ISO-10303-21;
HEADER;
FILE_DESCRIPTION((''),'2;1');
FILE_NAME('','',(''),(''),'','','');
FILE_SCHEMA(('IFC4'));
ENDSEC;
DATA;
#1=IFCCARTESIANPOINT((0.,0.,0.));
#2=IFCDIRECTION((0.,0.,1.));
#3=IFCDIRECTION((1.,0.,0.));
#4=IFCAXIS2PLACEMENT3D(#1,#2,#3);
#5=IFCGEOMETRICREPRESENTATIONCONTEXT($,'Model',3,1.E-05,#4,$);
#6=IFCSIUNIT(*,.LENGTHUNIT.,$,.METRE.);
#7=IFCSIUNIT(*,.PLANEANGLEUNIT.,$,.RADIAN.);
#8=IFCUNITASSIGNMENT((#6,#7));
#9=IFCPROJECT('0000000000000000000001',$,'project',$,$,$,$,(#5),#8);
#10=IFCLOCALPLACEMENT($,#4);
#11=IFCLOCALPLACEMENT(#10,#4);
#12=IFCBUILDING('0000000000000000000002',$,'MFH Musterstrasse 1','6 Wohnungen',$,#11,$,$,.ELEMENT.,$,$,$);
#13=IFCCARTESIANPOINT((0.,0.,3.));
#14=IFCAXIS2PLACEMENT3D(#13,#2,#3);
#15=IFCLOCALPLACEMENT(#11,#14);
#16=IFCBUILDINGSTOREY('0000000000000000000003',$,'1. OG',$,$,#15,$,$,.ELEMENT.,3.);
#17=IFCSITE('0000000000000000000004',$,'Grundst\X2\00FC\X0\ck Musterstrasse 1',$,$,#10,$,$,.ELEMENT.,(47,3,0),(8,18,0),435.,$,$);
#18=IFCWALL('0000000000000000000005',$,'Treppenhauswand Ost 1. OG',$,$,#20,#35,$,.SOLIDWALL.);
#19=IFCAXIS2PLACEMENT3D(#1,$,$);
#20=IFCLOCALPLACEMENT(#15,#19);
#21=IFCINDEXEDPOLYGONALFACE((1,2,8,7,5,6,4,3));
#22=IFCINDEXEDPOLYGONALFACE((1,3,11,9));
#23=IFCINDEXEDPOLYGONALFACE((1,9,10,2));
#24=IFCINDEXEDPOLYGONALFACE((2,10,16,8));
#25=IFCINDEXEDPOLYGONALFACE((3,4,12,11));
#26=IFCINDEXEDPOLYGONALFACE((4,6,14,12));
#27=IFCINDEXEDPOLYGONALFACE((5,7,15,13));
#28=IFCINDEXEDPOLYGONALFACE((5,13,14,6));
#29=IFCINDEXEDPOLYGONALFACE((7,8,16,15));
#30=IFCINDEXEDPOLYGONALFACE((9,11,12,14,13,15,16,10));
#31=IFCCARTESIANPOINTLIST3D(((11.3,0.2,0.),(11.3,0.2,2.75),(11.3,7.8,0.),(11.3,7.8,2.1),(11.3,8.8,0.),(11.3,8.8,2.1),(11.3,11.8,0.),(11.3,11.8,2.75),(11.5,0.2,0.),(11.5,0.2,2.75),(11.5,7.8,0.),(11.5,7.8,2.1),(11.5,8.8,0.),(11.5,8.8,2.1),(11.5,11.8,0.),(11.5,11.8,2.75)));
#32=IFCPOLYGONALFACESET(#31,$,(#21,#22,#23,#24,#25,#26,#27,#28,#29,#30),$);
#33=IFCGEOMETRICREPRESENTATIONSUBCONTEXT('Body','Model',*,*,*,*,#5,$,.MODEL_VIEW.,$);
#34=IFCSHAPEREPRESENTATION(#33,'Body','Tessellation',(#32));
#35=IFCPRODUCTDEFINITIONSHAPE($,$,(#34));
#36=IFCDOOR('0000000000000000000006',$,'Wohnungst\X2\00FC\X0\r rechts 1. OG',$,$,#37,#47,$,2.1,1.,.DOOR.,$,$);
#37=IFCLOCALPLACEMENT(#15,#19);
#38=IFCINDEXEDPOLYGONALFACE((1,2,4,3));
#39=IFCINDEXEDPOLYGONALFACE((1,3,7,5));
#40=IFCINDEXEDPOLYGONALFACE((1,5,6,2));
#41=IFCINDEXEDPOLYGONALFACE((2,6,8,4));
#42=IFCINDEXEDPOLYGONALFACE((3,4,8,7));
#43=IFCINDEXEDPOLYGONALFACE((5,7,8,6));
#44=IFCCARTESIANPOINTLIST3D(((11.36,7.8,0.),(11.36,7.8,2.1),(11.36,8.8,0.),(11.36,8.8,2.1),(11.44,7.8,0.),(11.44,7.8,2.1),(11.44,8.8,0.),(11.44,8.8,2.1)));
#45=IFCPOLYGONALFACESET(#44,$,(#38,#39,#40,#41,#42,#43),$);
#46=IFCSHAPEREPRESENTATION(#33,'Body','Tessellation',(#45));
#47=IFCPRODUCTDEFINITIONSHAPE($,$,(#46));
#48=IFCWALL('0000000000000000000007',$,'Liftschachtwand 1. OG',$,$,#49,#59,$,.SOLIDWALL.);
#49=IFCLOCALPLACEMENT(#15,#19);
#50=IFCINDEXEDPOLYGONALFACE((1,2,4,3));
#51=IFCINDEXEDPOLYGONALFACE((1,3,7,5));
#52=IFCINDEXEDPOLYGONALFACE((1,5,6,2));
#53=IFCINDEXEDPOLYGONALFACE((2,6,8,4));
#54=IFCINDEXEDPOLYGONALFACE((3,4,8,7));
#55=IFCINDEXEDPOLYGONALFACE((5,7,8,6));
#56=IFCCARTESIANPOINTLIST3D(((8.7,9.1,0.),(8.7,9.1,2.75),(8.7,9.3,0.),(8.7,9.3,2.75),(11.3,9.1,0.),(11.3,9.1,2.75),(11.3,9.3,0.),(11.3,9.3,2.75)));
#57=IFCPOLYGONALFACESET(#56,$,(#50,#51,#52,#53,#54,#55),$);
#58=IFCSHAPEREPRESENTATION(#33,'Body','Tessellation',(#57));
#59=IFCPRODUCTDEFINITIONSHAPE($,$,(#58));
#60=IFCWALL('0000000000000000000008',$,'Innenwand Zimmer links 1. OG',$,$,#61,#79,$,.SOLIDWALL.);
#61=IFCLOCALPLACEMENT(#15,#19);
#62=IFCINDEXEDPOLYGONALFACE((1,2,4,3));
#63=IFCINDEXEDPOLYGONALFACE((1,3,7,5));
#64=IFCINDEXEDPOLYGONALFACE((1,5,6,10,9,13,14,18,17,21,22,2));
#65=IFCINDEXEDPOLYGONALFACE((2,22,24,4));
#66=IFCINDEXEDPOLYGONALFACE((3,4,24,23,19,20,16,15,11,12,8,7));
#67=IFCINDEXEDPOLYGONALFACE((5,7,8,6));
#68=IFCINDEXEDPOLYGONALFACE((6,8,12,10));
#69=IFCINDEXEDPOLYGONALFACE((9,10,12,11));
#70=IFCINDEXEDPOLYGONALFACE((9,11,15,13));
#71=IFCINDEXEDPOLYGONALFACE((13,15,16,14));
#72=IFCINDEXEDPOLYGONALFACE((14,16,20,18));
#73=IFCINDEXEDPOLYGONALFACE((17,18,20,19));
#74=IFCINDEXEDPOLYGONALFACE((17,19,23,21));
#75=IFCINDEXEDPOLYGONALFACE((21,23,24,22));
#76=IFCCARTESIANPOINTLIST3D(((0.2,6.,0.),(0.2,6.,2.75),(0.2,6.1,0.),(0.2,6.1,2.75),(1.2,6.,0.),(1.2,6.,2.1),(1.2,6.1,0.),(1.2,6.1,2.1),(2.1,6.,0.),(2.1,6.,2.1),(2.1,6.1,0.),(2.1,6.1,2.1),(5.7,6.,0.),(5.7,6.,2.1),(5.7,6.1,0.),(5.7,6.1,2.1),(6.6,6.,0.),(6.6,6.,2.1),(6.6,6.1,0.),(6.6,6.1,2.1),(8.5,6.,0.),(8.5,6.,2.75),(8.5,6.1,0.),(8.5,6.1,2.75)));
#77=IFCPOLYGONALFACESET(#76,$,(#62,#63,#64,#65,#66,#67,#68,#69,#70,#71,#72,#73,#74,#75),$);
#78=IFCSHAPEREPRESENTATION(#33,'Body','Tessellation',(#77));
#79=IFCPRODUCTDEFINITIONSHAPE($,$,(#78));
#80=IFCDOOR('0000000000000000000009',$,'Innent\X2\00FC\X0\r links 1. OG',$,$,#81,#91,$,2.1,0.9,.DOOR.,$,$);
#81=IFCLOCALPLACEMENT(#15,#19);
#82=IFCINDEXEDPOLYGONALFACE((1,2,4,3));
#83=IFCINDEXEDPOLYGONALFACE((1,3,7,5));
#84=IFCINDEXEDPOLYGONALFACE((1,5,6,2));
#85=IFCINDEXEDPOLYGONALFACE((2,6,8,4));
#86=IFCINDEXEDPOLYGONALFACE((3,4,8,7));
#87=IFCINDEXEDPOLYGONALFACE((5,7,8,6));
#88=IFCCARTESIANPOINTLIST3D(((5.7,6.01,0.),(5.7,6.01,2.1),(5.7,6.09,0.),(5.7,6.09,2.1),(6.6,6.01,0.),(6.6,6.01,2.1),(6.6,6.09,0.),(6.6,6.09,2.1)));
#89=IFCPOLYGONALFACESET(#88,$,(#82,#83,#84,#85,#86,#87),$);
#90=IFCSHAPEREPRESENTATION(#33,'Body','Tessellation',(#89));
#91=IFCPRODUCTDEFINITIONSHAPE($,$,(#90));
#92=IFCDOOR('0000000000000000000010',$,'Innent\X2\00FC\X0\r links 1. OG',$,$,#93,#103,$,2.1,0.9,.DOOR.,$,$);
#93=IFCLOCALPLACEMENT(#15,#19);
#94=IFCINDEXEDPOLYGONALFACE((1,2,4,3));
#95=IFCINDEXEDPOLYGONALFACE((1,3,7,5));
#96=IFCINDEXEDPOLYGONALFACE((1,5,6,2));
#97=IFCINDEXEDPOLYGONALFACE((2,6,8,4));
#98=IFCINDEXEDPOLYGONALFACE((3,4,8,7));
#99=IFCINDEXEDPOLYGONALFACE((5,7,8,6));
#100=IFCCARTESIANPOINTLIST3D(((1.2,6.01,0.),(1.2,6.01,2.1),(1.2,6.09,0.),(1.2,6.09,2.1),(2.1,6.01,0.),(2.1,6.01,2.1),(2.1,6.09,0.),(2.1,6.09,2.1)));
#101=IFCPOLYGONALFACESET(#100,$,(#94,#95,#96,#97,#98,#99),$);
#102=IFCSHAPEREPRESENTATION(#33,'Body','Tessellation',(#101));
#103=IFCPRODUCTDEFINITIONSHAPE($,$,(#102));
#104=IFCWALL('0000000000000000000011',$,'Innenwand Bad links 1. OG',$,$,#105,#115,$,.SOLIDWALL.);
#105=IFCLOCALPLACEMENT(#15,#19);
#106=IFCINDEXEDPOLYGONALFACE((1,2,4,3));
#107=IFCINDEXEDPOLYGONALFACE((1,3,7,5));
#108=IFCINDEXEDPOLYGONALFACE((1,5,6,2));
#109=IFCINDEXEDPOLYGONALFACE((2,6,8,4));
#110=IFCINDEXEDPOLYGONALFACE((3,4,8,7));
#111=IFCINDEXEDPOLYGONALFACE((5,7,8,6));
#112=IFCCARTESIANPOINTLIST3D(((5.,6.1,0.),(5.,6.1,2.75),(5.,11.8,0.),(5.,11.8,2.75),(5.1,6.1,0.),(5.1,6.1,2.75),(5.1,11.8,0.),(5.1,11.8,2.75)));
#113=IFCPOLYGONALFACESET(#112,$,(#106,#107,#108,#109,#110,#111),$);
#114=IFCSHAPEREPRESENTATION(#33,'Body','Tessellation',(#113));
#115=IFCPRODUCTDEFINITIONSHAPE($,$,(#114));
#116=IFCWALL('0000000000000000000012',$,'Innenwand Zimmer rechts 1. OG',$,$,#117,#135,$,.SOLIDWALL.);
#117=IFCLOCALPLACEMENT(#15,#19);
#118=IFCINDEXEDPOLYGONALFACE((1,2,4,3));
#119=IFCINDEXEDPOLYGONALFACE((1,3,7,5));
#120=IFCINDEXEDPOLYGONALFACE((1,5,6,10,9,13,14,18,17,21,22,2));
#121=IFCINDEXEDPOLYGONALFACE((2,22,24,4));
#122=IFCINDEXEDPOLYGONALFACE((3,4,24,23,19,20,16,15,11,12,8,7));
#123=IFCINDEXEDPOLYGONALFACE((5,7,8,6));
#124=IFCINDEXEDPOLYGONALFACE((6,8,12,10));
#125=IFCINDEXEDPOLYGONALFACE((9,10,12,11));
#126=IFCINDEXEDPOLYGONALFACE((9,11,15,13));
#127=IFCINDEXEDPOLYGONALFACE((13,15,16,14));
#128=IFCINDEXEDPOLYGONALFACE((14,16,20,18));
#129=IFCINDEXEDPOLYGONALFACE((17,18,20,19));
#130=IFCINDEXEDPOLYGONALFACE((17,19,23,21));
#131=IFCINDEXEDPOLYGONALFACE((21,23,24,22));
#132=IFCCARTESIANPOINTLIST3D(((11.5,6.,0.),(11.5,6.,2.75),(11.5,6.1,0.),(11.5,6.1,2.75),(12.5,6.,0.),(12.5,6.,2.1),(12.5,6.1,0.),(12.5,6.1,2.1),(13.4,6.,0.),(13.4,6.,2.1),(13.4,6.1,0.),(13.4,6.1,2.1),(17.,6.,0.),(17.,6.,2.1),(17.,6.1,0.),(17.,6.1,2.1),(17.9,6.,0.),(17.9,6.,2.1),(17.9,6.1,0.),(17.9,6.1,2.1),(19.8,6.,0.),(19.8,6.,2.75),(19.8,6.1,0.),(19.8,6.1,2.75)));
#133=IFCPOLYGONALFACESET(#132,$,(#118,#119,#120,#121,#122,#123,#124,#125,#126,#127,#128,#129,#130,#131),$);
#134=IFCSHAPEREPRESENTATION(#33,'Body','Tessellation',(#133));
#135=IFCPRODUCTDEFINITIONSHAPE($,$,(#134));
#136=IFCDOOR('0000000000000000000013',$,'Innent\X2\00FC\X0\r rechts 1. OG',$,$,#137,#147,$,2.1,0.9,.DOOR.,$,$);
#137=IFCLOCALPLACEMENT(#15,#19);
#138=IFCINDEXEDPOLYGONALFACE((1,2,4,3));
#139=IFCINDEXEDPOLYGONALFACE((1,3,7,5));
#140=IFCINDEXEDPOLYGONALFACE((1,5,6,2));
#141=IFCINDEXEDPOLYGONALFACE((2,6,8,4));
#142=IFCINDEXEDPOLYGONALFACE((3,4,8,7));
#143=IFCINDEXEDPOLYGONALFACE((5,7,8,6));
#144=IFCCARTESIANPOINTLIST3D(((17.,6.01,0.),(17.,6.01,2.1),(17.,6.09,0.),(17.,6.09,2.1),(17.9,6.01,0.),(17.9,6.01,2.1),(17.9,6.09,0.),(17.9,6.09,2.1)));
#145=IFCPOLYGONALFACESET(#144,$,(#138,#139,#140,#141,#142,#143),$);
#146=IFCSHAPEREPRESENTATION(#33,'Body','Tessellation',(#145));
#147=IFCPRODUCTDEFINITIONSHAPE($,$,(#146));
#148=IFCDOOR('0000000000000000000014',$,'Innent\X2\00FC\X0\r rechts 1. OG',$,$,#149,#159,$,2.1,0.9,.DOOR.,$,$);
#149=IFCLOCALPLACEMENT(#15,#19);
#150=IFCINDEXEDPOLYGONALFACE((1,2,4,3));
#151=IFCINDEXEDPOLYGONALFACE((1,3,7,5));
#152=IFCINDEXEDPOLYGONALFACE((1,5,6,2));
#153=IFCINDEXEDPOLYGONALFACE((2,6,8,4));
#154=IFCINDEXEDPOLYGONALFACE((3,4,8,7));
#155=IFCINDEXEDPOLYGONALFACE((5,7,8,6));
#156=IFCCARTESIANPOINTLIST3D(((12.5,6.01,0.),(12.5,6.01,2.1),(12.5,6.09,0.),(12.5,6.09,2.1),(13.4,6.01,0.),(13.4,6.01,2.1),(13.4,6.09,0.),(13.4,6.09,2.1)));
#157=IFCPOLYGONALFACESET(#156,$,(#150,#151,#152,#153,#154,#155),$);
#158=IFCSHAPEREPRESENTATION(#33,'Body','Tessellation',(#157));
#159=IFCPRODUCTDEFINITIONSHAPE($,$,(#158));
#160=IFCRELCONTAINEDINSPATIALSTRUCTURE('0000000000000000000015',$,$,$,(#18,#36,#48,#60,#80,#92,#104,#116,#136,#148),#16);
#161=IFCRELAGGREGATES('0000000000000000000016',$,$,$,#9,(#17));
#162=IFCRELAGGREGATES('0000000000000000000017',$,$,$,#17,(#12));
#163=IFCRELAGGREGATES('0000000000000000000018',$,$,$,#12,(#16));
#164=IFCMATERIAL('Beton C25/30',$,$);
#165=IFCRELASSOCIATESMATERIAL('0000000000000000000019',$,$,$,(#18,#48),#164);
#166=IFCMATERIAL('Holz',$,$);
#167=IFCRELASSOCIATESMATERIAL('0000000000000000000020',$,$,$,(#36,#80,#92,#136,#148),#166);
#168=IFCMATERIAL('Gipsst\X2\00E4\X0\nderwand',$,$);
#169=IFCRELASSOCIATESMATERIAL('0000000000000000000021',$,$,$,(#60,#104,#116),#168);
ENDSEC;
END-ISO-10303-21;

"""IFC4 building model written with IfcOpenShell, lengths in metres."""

from ifc_helpers import new_model, si_unit, frame, frame_2d, origin_with_axes, place, context, subcontext, project, spatial, rectangle, extrude, material, element, fill, save


model = new_model("IFC4")

# Units and contexts
model_context = context("Model", 3, precision=1e-05, world=origin_with_axes())
body_context = subcontext(model_context, "Body", "Model", "MODEL_VIEW")
ifc_project = project(units=[si_unit("LENGTHUNIT", "METRE"), si_unit("PLANEANGLEUNIT", "RADIAN")], contexts=[model_context])

# Site, building, storey
site_placement = place(None, origin_with_axes())
site = spatial("IfcSite", under=ifc_project, at=site_placement, Name="Grundstück Musterstrasse 1", CompositionType="ELEMENT", RefLatitude=(47, 3, 0), RefLongitude=(8, 18, 0), RefElevation=435.0)
building_placement = place(site_placement, origin_with_axes())
building = spatial("IfcBuilding", under=site, at=building_placement, Name="MFH Musterstrasse 1", Description="6 Wohnungen", CompositionType="ELEMENT")
storey_placement = place(building_placement, frame((0.0, 0.0, 3.0), z_axis=(0.0, 0.0, 1.0), x_axis=(1.0, 0.0, 0.0)))
storey = spatial("IfcBuildingStorey", under=building, at=storey_placement, Name="1. OG", CompositionType="ELEMENT", Elevation=3.0)

# Wall, openings, door
ifc_material_1 = material(Name="Beton C25/30")
wall_1_placement = place(storey_placement, origin_with_axes())
wall_1 = element("IfcWall", 1, at=wall_1_placement, inside=storey, material=ifc_material_1, Name="Treppenhauswand Ost 1. OG", PredefinedType="SOLIDWALL", context=body_context, shape_type="SweptSolid", body=[
    extrude(rectangle(XDim=0.2, YDim=11.6, at=frame_2d((0.1, 5.8), x_axis=(1.0, 0.0))), frame((11.3, 0.2, 0.0), z_axis=(0.0, 0.0, 1.0), x_axis=(1.0, 0.0, 0.0)), (0.0, 0.0, 1.0), 2.75),
])
opening_1_placement = place(storey_placement, origin_with_axes())
element("IfcOpeningElement", 2, at=opening_1_placement, cuts=wall_1, PredefinedType="OPENING", context=body_context, shape_type="SweptSolid", body=[
    extrude(rectangle(XDim=0.3, YDim=1.0, at=frame_2d((0.15, 0.5), x_axis=(1.0, 0.0))), frame((11.25, 7.8, 0.0), z_axis=(0.0, 0.0, 1.0), x_axis=(1.0, 0.0, 0.0)), (0.0, 0.0, 1.0), 2.1),
])
opening_2_placement = place(storey_placement, origin_with_axes())
opening_2 = element("IfcOpeningElement", 3, at=opening_2_placement, cuts=wall_1, PredefinedType="OPENING", context=body_context, shape_type="SweptSolid", body=[
    extrude(rectangle(XDim=0.22, YDim=1.0, at=frame_2d((0.11, 0.5), x_axis=(1.0, 0.0))), frame((11.29, 7.8, 0.0), z_axis=(0.0, 0.0, 1.0), x_axis=(1.0, 0.0, 0.0)), (0.0, 0.0, 1.0), 2.1),
])
ifc_material_2 = material(Name="Holz")
door_1_placement = place(storey_placement, origin_with_axes())
door_1 = element("IfcDoor", 4, at=door_1_placement, inside=storey, material=ifc_material_2, Name="Wohnungstür rechts 1. OG", OverallHeight=2.1, OverallWidth=1.0, PredefinedType="DOOR", context=body_context, shape_type="SweptSolid", body=[
    extrude(rectangle(XDim=0.08, YDim=1.0, at=frame_2d((0.04, 0.5), x_axis=(1.0, 0.0))), frame((11.36, 7.8, 0.0), z_axis=(0.0, 0.0, 1.0), x_axis=(1.0, 0.0, 0.0)), (0.0, 0.0, 1.0), 2.1),
])
fill(opening_2, door_1)

# Wall
wall_2_placement = place(storey_placement, origin_with_axes())
element("IfcWall", 5, at=wall_2_placement, inside=storey, material=ifc_material_1, Name="Liftschachtwand 1. OG", PredefinedType="SOLIDWALL", context=body_context, shape_type="SweptSolid", body=[
    extrude(rectangle(XDim=2.6, YDim=0.2, at=frame_2d((1.3, 0.1), x_axis=(1.0, 0.0))), frame((8.7, 9.1, 0.0), z_axis=(0.0, 0.0, 1.0), x_axis=(1.0, 0.0, 0.0)), (0.0, 0.0, 1.0), 2.75),
])

# Wall, openings, doors
ifc_material_3 = material(Name="Gipsständerwand")
wall_3_placement = place(storey_placement, origin_with_axes())
wall_3 = element("IfcWall", 6, at=wall_3_placement, inside=storey, material=ifc_material_3, Name="Innenwand Zimmer links 1. OG", PredefinedType="SOLIDWALL", context=body_context, shape_type="SweptSolid", body=[
    extrude(rectangle(XDim=8.3, YDim=0.1, at=frame_2d((4.15, 0.05), x_axis=(1.0, 0.0))), frame((0.2, 6.0, 0.0), z_axis=(0.0, 0.0, 1.0), x_axis=(1.0, 0.0, 0.0)), (0.0, 0.0, 1.0), 2.75),
])
opening_3_placement = place(storey_placement, origin_with_axes())
element("IfcOpeningElement", 7, at=opening_3_placement, cuts=wall_3, PredefinedType="OPENING", context=body_context, shape_type="SweptSolid", body=[
    extrude(rectangle(XDim=0.9, YDim=0.2, at=frame_2d((0.45, 0.1), x_axis=(1.0, 0.0))), frame((5.7, 5.95, 0.0), z_axis=(0.0, 0.0, 1.0), x_axis=(1.0, 0.0, 0.0)), (0.0, 0.0, 1.0), 2.1),
])
opening_4_placement = place(storey_placement, origin_with_axes())
element("IfcOpeningElement", 8, at=opening_4_placement, cuts=wall_3, PredefinedType="OPENING", context=body_context, shape_type="SweptSolid", body=[
    extrude(rectangle(XDim=0.9, YDim=0.2, at=frame_2d((0.45, 0.1), x_axis=(1.0, 0.0))), frame((1.2, 5.95, 0.0), z_axis=(0.0, 0.0, 1.0), x_axis=(1.0, 0.0, 0.0)), (0.0, 0.0, 1.0), 2.1),
])
opening_5_placement = place(storey_placement, origin_with_axes())
opening_5 = element("IfcOpeningElement", 9, at=opening_5_placement, cuts=wall_3, PredefinedType="OPENING", context=body_context, shape_type="SweptSolid", body=[
    extrude(rectangle(XDim=0.9, YDim=0.12, at=frame_2d((0.45, 0.06), x_axis=(1.0, 0.0))), frame((5.7, 5.99, 0.0), z_axis=(0.0, 0.0, 1.0), x_axis=(1.0, 0.0, 0.0)), (0.0, 0.0, 1.0), 2.1),
])
opening_6_placement = place(storey_placement, origin_with_axes())
opening_6 = element("IfcOpeningElement", 10, at=opening_6_placement, cuts=wall_3, PredefinedType="OPENING", context=body_context, shape_type="SweptSolid", body=[
    extrude(rectangle(XDim=0.9, YDim=0.12, at=frame_2d((0.45, 0.06), x_axis=(1.0, 0.0))), frame((1.2, 5.99, 0.0), z_axis=(0.0, 0.0, 1.0), x_axis=(1.0, 0.0, 0.0)), (0.0, 0.0, 1.0), 2.1),
])
door_2_placement = place(storey_placement, origin_with_axes())
door_2 = element("IfcDoor", 11, at=door_2_placement, inside=storey, material=ifc_material_2, Name="Innentür links 1. OG", OverallHeight=2.1, OverallWidth=0.9, PredefinedType="DOOR", context=body_context, shape_type="SweptSolid", body=[
    extrude(rectangle(XDim=0.9, YDim=0.08, at=frame_2d((0.45, 0.04), x_axis=(1.0, 0.0))), frame((5.7, 6.01, 0.0), z_axis=(0.0, 0.0, 1.0), x_axis=(1.0, 0.0, 0.0)), (0.0, 0.0, 1.0), 2.1),
])
fill(opening_5, door_2)
door_3_placement = place(storey_placement, origin_with_axes())
door_3 = element("IfcDoor", 12, at=door_3_placement, inside=storey, material=ifc_material_2, Name="Innentür links 1. OG", OverallHeight=2.1, OverallWidth=0.9, PredefinedType="DOOR", context=body_context, shape_type="SweptSolid", body=[
    extrude(rectangle(XDim=0.9, YDim=0.08, at=frame_2d((0.45, 0.04), x_axis=(1.0, 0.0))), frame((1.2, 6.01, 0.0), z_axis=(0.0, 0.0, 1.0), x_axis=(1.0, 0.0, 0.0)), (0.0, 0.0, 1.0), 2.1),
])
fill(opening_6, door_3)

# Wall
wall_4_placement = place(storey_placement, origin_with_axes())
element("IfcWall", 13, at=wall_4_placement, inside=storey, material=ifc_material_3, Name="Innenwand Bad links 1. OG", PredefinedType="SOLIDWALL", context=body_context, shape_type="SweptSolid", body=[
    extrude(rectangle(XDim=0.1, YDim=5.7, at=frame_2d((0.05, 2.85), x_axis=(1.0, 0.0))), frame((5.0, 6.1, 0.0), z_axis=(0.0, 0.0, 1.0), x_axis=(1.0, 0.0, 0.0)), (0.0, 0.0, 1.0), 2.75),
])

# Wall, openings, doors
wall_5_placement = place(storey_placement, origin_with_axes())
wall_5 = element("IfcWall", 14, at=wall_5_placement, inside=storey, material=ifc_material_3, Name="Innenwand Zimmer rechts 1. OG", PredefinedType="SOLIDWALL", context=body_context, shape_type="SweptSolid", body=[
    extrude(rectangle(XDim=8.3, YDim=0.1, at=frame_2d((4.15, 0.05), x_axis=(1.0, 0.0))), frame((11.5, 6.0, 0.0), z_axis=(0.0, 0.0, 1.0), x_axis=(1.0, 0.0, 0.0)), (0.0, 0.0, 1.0), 2.75),
])
opening_7_placement = place(storey_placement, origin_with_axes())
element("IfcOpeningElement", 15, at=opening_7_placement, cuts=wall_5, PredefinedType="OPENING", context=body_context, shape_type="SweptSolid", body=[
    extrude(rectangle(XDim=0.9, YDim=0.2, at=frame_2d((0.45, 0.1), x_axis=(1.0, 0.0))), frame((17.0, 5.95, 0.0), z_axis=(0.0, 0.0, 1.0), x_axis=(1.0, 0.0, 0.0)), (0.0, 0.0, 1.0), 2.1),
])
opening_8_placement = place(storey_placement, origin_with_axes())
element("IfcOpeningElement", 16, at=opening_8_placement, cuts=wall_5, PredefinedType="OPENING", context=body_context, shape_type="SweptSolid", body=[
    extrude(rectangle(XDim=0.9, YDim=0.2, at=frame_2d((0.45, 0.1), x_axis=(1.0, 0.0))), frame((12.5, 5.95, 0.0), z_axis=(0.0, 0.0, 1.0), x_axis=(1.0, 0.0, 0.0)), (0.0, 0.0, 1.0), 2.1),
])
opening_9_placement = place(storey_placement, origin_with_axes())
opening_9 = element("IfcOpeningElement", 17, at=opening_9_placement, cuts=wall_5, PredefinedType="OPENING", context=body_context, shape_type="SweptSolid", body=[
    extrude(rectangle(XDim=0.9, YDim=0.12, at=frame_2d((0.45, 0.06), x_axis=(1.0, 0.0))), frame((17.0, 5.99, 0.0), z_axis=(0.0, 0.0, 1.0), x_axis=(1.0, 0.0, 0.0)), (0.0, 0.0, 1.0), 2.1),
])
opening_10_placement = place(storey_placement, origin_with_axes())
opening_10 = element("IfcOpeningElement", 18, at=opening_10_placement, cuts=wall_5, PredefinedType="OPENING", context=body_context, shape_type="SweptSolid", body=[
    extrude(rectangle(XDim=0.9, YDim=0.12, at=frame_2d((0.45, 0.06), x_axis=(1.0, 0.0))), frame((12.5, 5.99, 0.0), z_axis=(0.0, 0.0, 1.0), x_axis=(1.0, 0.0, 0.0)), (0.0, 0.0, 1.0), 2.1),
])
door_4_placement = place(storey_placement, origin_with_axes())
door_4 = element("IfcDoor", 19, at=door_4_placement, inside=storey, material=ifc_material_2, Name="Innentür rechts 1. OG", OverallHeight=2.1, OverallWidth=0.9, PredefinedType="DOOR", context=body_context, shape_type="SweptSolid", body=[
    extrude(rectangle(XDim=0.9, YDim=0.08, at=frame_2d((0.45, 0.04), x_axis=(1.0, 0.0))), frame((17.0, 6.01, 0.0), z_axis=(0.0, 0.0, 1.0), x_axis=(1.0, 0.0, 0.0)), (0.0, 0.0, 1.0), 2.1),
])
fill(opening_9, door_4)
door_5_placement = place(storey_placement, origin_with_axes())
door_5 = element("IfcDoor", 20, at=door_5_placement, inside=storey, material=ifc_material_2, Name="Innentür rechts 1. OG", OverallHeight=2.1, OverallWidth=0.9, PredefinedType="DOOR", context=body_context, shape_type="SweptSolid", body=[
    extrude(rectangle(XDim=0.9, YDim=0.08, at=frame_2d((0.45, 0.04), x_axis=(1.0, 0.0))), frame((12.5, 6.01, 0.0), z_axis=(0.0, 0.0, 1.0), x_axis=(1.0, 0.0, 0.0)), (0.0, 0.0, 1.0), 2.1),
])
fill(opening_10, door_5)

save(model, "model.ifc")
